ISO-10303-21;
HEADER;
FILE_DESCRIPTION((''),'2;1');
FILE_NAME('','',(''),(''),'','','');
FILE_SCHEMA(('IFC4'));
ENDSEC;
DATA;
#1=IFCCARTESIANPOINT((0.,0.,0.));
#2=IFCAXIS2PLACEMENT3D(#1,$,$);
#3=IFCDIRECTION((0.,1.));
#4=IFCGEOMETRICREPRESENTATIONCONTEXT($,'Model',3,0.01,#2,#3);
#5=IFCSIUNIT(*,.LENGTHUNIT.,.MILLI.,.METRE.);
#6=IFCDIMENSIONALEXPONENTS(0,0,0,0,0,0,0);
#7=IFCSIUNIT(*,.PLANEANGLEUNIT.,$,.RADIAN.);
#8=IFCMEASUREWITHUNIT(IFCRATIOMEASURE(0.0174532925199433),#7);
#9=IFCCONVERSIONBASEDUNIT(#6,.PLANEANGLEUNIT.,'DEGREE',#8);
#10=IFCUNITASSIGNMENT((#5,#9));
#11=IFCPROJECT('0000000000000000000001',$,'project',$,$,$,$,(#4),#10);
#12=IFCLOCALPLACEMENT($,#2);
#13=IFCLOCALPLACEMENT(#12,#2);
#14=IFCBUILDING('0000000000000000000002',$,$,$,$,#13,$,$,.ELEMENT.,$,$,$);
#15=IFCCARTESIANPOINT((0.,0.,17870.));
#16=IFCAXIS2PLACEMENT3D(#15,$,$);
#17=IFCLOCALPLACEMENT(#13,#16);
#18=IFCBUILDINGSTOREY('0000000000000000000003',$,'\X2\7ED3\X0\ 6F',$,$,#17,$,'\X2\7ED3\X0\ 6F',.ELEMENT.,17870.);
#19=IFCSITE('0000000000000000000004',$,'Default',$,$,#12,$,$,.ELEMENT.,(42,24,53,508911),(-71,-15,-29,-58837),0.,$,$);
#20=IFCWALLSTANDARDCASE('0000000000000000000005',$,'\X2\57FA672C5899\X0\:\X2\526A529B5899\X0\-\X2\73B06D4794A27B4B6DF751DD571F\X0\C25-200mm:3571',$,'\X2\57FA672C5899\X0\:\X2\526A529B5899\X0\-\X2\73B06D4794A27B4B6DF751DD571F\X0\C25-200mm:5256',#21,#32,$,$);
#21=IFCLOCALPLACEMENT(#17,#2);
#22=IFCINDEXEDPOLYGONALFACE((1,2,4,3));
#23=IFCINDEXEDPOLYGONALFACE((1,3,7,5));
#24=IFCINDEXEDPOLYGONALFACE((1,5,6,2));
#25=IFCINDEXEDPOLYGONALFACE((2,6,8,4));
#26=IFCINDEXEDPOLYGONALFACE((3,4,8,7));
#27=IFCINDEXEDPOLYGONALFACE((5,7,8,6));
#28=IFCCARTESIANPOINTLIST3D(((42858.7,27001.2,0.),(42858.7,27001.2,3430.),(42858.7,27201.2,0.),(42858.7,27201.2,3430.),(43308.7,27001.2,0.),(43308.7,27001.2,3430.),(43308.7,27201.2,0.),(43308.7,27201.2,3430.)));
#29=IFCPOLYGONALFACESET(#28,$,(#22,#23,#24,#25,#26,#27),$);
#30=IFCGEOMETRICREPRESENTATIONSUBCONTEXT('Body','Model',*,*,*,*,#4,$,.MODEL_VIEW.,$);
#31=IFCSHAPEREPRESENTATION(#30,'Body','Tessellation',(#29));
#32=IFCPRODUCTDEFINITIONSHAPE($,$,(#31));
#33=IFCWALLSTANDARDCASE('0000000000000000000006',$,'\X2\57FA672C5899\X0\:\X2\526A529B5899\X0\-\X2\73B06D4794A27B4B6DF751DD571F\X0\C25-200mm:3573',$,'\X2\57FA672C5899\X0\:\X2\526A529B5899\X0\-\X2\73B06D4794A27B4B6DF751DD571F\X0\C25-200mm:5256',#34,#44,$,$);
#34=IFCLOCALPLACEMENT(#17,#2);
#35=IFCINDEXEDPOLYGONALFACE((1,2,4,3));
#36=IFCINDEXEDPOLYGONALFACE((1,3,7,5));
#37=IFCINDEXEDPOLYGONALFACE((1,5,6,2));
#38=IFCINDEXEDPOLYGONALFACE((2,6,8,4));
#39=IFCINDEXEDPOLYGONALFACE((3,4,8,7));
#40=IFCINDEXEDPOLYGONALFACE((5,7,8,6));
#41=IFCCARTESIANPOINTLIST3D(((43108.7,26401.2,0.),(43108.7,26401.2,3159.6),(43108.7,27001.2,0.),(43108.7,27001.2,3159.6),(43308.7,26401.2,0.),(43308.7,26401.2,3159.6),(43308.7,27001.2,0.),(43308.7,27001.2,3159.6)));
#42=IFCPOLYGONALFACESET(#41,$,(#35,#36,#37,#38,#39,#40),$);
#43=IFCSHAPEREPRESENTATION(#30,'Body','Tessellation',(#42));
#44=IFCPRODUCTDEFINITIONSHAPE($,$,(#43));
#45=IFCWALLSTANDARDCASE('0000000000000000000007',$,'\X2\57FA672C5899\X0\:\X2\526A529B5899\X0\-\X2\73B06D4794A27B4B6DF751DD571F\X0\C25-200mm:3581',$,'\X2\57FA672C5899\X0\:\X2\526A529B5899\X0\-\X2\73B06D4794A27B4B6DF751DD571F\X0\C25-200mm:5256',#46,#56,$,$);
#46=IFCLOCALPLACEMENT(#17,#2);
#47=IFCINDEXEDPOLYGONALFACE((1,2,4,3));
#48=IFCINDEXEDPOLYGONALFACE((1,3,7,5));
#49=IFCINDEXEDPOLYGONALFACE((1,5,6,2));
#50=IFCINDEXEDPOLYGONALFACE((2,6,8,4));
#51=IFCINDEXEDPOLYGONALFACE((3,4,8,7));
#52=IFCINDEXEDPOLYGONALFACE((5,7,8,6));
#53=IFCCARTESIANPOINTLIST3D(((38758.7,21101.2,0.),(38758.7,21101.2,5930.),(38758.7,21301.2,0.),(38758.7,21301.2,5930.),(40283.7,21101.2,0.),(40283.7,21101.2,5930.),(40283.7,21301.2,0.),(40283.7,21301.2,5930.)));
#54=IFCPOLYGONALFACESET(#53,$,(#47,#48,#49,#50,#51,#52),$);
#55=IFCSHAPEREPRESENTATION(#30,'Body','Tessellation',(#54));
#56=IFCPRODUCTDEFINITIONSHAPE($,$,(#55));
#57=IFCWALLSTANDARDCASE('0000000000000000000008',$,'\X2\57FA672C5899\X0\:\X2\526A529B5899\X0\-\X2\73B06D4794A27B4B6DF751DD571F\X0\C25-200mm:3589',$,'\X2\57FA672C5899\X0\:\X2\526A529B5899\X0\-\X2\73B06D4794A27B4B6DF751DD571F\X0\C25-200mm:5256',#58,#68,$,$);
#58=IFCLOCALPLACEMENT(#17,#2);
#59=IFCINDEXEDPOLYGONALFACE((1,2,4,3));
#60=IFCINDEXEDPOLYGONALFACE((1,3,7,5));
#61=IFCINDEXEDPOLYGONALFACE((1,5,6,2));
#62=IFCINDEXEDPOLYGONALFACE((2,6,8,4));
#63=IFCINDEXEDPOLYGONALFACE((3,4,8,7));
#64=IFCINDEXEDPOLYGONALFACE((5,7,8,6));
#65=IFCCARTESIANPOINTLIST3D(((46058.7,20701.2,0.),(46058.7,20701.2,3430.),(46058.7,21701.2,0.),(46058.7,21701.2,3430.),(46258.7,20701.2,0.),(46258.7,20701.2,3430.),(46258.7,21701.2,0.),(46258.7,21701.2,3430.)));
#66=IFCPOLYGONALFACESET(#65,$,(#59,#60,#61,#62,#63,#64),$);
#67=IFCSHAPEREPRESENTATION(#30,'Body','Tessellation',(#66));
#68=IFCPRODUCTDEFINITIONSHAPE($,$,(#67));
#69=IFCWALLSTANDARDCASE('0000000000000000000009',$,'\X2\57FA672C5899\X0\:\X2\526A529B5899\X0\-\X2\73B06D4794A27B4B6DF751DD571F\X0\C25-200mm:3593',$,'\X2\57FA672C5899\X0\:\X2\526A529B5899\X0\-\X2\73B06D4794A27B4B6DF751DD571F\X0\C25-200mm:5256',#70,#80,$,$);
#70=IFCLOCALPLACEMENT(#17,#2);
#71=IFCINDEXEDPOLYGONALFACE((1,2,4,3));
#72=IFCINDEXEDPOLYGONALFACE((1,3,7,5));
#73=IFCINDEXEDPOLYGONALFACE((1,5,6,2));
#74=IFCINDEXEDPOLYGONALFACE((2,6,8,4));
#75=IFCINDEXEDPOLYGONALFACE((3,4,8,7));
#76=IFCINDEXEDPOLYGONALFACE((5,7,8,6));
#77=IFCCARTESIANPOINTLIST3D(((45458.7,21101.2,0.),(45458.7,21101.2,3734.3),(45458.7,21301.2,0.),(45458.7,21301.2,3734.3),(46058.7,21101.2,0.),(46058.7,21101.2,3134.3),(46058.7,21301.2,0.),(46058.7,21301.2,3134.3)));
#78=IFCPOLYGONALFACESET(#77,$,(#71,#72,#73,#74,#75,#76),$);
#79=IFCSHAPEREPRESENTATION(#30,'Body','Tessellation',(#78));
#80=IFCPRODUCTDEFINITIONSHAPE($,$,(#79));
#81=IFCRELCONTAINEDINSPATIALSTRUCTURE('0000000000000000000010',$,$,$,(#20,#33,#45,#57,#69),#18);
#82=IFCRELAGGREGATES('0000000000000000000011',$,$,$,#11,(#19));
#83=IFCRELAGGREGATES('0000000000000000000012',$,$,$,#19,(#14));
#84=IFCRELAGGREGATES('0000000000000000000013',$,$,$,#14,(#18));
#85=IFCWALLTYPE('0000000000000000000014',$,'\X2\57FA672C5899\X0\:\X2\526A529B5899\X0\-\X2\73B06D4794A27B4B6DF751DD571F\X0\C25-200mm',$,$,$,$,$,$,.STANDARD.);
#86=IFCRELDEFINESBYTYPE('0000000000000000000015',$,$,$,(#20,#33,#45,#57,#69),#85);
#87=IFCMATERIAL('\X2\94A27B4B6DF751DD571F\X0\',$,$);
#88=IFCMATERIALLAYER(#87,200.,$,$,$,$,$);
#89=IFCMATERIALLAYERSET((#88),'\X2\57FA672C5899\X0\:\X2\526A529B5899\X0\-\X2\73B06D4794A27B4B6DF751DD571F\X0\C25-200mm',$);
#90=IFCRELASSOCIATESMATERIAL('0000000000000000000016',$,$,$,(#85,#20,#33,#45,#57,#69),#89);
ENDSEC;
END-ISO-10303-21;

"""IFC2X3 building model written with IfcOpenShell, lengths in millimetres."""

from ifc_helpers import new_model, entity, si_unit, converted_unit, direction, frame, frame_2d, origin, place, context, subcontext, project, spatial, rectangle, extrude, clip, halfspace, material, layer, layer_set, layer_usage, type_object, element, save


model = new_model("IFC2X3")

# Units and contexts
model_context = context("Model", 3, precision=0.01, world=origin(), true_north=direction((0.0, 1.0)))
body_context = subcontext(model_context, "Body", "Model", "MODEL_VIEW")
ifc_project = project(units=[si_unit("LENGTHUNIT", "METRE", prefix="MILLI"), converted_unit("PLANEANGLEUNIT", "DEGREE", entity("IfcRatioMeasure", 0.0174532925199433), si_unit("PLANEANGLEUNIT", "RADIAN"), dimensions=[0, 0, 0, 0, 0, 0, 0])], contexts=[model_context])

# Site, building, storey
site_placement = place(None, origin())
site = spatial("IfcSite", under=ifc_project, at=site_placement, Name="Default", CompositionType="ELEMENT", RefLatitude=(42, 24, 53, 508911), RefLongitude=(-71, -15, -29, -58837), RefElevation=0.0)
building_placement = place(site_placement, origin())
building = spatial("IfcBuilding", under=site, at=building_placement, CompositionType="ELEMENT")
storey_placement = place(building_placement, frame((0.0, 0.0, 17870.0)))
storey = spatial("IfcBuildingStorey", under=building, at=storey_placement, Name="结 6F", LongName="结 6F", CompositionType="ELEMENT", Elevation=17870.0)

# Shared definitions
ifc_material = material(Name="钢筋混凝土")

# Walls
ifc_layer = layer(ifc_material, 200.0)
ifc_layer_set = layer_set([ifc_layer], Name="基本墙:剪力墙-现浇钢筋混凝土C25-200mm")
wall_type = type_object("IfcWallType", Name="基本墙:剪力墙-现浇钢筋混凝土C25-200mm", PredefinedType="STANDARD", material=ifc_layer_set)
ifc_layer_usage_1 = layer_usage(ifc_layer_set, "AXIS2", "POSITIVE", -100.0)
wall_1_placement = place(storey_placement, frame((42858.7, 27101.2, 0.0)))
element("IfcWallStandardCase", 1, at=wall_1_placement, inside=storey, type_object=wall_type, material=ifc_layer_usage_1, Name="基本墙:剪力墙-现浇钢筋混凝土C25-200mm:3571", ObjectType="基本墙:剪力墙-现浇钢筋混凝土C25-200mm:5256", context=body_context, shape_type="SweptSolid", body=[
    extrude(rectangle(XDim=450.0, YDim=200.0, at=frame_2d((225.0, 0.0), x_axis=(-1.0, 0.0))), origin(), (0.0, 0.0, 1.0), 3430.0),
])
ifc_layer_usage_2 = layer_usage(ifc_layer_set, "AXIS2", "POSITIVE", -100.0)
wall_2_placement = place(storey_placement, frame((43208.7, 27001.2, 0.0), z_axis=(0.0, 0.0, 1.0), x_axis=(0.0, -1.0, 0.0)))
element("IfcWallStandardCase", 2, at=wall_2_placement, inside=storey, type_object=wall_type, material=ifc_layer_usage_2, Name="基本墙:剪力墙-现浇钢筋混凝土C25-200mm:3573", ObjectType="基本墙:剪力墙-现浇钢筋混凝土C25-200mm:5256", context=body_context, shape_type="SweptSolid", body=[
    extrude(rectangle(XDim=600.0, YDim=200.0, at=frame_2d((300.0, 0.0), x_axis=(-1.0, 0.0))), origin(), (0.0, 0.0, 1.0), 3159.6),
])
ifc_layer_usage_3 = layer_usage(ifc_layer_set, "AXIS2", "POSITIVE", -100.0)
wall_3_placement = place(storey_placement, frame((40283.7, 21201.2, 0.0), z_axis=(0.0, 0.0, 1.0), x_axis=(-1.0, 0.0, 0.0)))
element("IfcWallStandardCase", 3, at=wall_3_placement, inside=storey, type_object=wall_type, material=ifc_layer_usage_3, Name="基本墙:剪力墙-现浇钢筋混凝土C25-200mm:3581", ObjectType="基本墙:剪力墙-现浇钢筋混凝土C25-200mm:5256", context=body_context, shape_type="SweptSolid", body=[
    extrude(rectangle(XDim=1525.0, YDim=200.0, at=frame_2d((762.5, 0.0), x_axis=(-1.0, 0.0))), origin(), (0.0, 0.0, 1.0), 5930.0),
])
ifc_layer_usage_4 = layer_usage(ifc_layer_set, "AXIS2", "NEGATIVE", 100.0)
wall_4_placement = place(storey_placement, frame((46158.7, 21701.2, 0.0), z_axis=(0.0, 0.0, 1.0), x_axis=(0.0, -1.0, 0.0)))
element("IfcWallStandardCase", 4, at=wall_4_placement, inside=storey, type_object=wall_type, material=ifc_layer_usage_4, Name="基本墙:剪力墙-现浇钢筋混凝土C25-200mm:3589", ObjectType="基本墙:剪力墙-现浇钢筋混凝土C25-200mm:5256", context=body_context, shape_type="SweptSolid", body=[
    extrude(rectangle(XDim=1000.0, YDim=200.0, at=frame_2d((500.0, 0.0), x_axis=(-1.0, 0.0))), origin(), (0.0, 0.0, 1.0), 3430.0),
])
ifc_layer_usage_5 = layer_usage(ifc_layer_set, "AXIS2", "NEGATIVE", 100.0)
wall_5_placement = place(storey_placement, frame((46058.7, 21201.2, 0.0), z_axis=(0.0, 0.0, 1.0), x_axis=(-1.0, 0.0, 0.0)))
element("IfcWallStandardCase", 5, at=wall_5_placement, inside=storey, type_object=wall_type, material=ifc_layer_usage_5, Name="基本墙:剪力墙-现浇钢筋混凝土C25-200mm:3593", ObjectType="基本墙:剪力墙-现浇钢筋混凝土C25-200mm:5256", context=body_context, shape_type="Clipping", body=[
    clip(extrude(rectangle(XDim=600.0, YDim=200.0, at=frame_2d((300.0, 0.0), x_axis=(-1.0, 0.0))), origin(), (0.0, 0.0, 1.0), 3734.3), halfspace(frame((0.0, -100.0, 3134.3), z_axis=(-0.707107, 0.0, 0.707107), x_axis=(0.0, 1.0, 0.0)), False)),
])

save(model, "model.ifc")
